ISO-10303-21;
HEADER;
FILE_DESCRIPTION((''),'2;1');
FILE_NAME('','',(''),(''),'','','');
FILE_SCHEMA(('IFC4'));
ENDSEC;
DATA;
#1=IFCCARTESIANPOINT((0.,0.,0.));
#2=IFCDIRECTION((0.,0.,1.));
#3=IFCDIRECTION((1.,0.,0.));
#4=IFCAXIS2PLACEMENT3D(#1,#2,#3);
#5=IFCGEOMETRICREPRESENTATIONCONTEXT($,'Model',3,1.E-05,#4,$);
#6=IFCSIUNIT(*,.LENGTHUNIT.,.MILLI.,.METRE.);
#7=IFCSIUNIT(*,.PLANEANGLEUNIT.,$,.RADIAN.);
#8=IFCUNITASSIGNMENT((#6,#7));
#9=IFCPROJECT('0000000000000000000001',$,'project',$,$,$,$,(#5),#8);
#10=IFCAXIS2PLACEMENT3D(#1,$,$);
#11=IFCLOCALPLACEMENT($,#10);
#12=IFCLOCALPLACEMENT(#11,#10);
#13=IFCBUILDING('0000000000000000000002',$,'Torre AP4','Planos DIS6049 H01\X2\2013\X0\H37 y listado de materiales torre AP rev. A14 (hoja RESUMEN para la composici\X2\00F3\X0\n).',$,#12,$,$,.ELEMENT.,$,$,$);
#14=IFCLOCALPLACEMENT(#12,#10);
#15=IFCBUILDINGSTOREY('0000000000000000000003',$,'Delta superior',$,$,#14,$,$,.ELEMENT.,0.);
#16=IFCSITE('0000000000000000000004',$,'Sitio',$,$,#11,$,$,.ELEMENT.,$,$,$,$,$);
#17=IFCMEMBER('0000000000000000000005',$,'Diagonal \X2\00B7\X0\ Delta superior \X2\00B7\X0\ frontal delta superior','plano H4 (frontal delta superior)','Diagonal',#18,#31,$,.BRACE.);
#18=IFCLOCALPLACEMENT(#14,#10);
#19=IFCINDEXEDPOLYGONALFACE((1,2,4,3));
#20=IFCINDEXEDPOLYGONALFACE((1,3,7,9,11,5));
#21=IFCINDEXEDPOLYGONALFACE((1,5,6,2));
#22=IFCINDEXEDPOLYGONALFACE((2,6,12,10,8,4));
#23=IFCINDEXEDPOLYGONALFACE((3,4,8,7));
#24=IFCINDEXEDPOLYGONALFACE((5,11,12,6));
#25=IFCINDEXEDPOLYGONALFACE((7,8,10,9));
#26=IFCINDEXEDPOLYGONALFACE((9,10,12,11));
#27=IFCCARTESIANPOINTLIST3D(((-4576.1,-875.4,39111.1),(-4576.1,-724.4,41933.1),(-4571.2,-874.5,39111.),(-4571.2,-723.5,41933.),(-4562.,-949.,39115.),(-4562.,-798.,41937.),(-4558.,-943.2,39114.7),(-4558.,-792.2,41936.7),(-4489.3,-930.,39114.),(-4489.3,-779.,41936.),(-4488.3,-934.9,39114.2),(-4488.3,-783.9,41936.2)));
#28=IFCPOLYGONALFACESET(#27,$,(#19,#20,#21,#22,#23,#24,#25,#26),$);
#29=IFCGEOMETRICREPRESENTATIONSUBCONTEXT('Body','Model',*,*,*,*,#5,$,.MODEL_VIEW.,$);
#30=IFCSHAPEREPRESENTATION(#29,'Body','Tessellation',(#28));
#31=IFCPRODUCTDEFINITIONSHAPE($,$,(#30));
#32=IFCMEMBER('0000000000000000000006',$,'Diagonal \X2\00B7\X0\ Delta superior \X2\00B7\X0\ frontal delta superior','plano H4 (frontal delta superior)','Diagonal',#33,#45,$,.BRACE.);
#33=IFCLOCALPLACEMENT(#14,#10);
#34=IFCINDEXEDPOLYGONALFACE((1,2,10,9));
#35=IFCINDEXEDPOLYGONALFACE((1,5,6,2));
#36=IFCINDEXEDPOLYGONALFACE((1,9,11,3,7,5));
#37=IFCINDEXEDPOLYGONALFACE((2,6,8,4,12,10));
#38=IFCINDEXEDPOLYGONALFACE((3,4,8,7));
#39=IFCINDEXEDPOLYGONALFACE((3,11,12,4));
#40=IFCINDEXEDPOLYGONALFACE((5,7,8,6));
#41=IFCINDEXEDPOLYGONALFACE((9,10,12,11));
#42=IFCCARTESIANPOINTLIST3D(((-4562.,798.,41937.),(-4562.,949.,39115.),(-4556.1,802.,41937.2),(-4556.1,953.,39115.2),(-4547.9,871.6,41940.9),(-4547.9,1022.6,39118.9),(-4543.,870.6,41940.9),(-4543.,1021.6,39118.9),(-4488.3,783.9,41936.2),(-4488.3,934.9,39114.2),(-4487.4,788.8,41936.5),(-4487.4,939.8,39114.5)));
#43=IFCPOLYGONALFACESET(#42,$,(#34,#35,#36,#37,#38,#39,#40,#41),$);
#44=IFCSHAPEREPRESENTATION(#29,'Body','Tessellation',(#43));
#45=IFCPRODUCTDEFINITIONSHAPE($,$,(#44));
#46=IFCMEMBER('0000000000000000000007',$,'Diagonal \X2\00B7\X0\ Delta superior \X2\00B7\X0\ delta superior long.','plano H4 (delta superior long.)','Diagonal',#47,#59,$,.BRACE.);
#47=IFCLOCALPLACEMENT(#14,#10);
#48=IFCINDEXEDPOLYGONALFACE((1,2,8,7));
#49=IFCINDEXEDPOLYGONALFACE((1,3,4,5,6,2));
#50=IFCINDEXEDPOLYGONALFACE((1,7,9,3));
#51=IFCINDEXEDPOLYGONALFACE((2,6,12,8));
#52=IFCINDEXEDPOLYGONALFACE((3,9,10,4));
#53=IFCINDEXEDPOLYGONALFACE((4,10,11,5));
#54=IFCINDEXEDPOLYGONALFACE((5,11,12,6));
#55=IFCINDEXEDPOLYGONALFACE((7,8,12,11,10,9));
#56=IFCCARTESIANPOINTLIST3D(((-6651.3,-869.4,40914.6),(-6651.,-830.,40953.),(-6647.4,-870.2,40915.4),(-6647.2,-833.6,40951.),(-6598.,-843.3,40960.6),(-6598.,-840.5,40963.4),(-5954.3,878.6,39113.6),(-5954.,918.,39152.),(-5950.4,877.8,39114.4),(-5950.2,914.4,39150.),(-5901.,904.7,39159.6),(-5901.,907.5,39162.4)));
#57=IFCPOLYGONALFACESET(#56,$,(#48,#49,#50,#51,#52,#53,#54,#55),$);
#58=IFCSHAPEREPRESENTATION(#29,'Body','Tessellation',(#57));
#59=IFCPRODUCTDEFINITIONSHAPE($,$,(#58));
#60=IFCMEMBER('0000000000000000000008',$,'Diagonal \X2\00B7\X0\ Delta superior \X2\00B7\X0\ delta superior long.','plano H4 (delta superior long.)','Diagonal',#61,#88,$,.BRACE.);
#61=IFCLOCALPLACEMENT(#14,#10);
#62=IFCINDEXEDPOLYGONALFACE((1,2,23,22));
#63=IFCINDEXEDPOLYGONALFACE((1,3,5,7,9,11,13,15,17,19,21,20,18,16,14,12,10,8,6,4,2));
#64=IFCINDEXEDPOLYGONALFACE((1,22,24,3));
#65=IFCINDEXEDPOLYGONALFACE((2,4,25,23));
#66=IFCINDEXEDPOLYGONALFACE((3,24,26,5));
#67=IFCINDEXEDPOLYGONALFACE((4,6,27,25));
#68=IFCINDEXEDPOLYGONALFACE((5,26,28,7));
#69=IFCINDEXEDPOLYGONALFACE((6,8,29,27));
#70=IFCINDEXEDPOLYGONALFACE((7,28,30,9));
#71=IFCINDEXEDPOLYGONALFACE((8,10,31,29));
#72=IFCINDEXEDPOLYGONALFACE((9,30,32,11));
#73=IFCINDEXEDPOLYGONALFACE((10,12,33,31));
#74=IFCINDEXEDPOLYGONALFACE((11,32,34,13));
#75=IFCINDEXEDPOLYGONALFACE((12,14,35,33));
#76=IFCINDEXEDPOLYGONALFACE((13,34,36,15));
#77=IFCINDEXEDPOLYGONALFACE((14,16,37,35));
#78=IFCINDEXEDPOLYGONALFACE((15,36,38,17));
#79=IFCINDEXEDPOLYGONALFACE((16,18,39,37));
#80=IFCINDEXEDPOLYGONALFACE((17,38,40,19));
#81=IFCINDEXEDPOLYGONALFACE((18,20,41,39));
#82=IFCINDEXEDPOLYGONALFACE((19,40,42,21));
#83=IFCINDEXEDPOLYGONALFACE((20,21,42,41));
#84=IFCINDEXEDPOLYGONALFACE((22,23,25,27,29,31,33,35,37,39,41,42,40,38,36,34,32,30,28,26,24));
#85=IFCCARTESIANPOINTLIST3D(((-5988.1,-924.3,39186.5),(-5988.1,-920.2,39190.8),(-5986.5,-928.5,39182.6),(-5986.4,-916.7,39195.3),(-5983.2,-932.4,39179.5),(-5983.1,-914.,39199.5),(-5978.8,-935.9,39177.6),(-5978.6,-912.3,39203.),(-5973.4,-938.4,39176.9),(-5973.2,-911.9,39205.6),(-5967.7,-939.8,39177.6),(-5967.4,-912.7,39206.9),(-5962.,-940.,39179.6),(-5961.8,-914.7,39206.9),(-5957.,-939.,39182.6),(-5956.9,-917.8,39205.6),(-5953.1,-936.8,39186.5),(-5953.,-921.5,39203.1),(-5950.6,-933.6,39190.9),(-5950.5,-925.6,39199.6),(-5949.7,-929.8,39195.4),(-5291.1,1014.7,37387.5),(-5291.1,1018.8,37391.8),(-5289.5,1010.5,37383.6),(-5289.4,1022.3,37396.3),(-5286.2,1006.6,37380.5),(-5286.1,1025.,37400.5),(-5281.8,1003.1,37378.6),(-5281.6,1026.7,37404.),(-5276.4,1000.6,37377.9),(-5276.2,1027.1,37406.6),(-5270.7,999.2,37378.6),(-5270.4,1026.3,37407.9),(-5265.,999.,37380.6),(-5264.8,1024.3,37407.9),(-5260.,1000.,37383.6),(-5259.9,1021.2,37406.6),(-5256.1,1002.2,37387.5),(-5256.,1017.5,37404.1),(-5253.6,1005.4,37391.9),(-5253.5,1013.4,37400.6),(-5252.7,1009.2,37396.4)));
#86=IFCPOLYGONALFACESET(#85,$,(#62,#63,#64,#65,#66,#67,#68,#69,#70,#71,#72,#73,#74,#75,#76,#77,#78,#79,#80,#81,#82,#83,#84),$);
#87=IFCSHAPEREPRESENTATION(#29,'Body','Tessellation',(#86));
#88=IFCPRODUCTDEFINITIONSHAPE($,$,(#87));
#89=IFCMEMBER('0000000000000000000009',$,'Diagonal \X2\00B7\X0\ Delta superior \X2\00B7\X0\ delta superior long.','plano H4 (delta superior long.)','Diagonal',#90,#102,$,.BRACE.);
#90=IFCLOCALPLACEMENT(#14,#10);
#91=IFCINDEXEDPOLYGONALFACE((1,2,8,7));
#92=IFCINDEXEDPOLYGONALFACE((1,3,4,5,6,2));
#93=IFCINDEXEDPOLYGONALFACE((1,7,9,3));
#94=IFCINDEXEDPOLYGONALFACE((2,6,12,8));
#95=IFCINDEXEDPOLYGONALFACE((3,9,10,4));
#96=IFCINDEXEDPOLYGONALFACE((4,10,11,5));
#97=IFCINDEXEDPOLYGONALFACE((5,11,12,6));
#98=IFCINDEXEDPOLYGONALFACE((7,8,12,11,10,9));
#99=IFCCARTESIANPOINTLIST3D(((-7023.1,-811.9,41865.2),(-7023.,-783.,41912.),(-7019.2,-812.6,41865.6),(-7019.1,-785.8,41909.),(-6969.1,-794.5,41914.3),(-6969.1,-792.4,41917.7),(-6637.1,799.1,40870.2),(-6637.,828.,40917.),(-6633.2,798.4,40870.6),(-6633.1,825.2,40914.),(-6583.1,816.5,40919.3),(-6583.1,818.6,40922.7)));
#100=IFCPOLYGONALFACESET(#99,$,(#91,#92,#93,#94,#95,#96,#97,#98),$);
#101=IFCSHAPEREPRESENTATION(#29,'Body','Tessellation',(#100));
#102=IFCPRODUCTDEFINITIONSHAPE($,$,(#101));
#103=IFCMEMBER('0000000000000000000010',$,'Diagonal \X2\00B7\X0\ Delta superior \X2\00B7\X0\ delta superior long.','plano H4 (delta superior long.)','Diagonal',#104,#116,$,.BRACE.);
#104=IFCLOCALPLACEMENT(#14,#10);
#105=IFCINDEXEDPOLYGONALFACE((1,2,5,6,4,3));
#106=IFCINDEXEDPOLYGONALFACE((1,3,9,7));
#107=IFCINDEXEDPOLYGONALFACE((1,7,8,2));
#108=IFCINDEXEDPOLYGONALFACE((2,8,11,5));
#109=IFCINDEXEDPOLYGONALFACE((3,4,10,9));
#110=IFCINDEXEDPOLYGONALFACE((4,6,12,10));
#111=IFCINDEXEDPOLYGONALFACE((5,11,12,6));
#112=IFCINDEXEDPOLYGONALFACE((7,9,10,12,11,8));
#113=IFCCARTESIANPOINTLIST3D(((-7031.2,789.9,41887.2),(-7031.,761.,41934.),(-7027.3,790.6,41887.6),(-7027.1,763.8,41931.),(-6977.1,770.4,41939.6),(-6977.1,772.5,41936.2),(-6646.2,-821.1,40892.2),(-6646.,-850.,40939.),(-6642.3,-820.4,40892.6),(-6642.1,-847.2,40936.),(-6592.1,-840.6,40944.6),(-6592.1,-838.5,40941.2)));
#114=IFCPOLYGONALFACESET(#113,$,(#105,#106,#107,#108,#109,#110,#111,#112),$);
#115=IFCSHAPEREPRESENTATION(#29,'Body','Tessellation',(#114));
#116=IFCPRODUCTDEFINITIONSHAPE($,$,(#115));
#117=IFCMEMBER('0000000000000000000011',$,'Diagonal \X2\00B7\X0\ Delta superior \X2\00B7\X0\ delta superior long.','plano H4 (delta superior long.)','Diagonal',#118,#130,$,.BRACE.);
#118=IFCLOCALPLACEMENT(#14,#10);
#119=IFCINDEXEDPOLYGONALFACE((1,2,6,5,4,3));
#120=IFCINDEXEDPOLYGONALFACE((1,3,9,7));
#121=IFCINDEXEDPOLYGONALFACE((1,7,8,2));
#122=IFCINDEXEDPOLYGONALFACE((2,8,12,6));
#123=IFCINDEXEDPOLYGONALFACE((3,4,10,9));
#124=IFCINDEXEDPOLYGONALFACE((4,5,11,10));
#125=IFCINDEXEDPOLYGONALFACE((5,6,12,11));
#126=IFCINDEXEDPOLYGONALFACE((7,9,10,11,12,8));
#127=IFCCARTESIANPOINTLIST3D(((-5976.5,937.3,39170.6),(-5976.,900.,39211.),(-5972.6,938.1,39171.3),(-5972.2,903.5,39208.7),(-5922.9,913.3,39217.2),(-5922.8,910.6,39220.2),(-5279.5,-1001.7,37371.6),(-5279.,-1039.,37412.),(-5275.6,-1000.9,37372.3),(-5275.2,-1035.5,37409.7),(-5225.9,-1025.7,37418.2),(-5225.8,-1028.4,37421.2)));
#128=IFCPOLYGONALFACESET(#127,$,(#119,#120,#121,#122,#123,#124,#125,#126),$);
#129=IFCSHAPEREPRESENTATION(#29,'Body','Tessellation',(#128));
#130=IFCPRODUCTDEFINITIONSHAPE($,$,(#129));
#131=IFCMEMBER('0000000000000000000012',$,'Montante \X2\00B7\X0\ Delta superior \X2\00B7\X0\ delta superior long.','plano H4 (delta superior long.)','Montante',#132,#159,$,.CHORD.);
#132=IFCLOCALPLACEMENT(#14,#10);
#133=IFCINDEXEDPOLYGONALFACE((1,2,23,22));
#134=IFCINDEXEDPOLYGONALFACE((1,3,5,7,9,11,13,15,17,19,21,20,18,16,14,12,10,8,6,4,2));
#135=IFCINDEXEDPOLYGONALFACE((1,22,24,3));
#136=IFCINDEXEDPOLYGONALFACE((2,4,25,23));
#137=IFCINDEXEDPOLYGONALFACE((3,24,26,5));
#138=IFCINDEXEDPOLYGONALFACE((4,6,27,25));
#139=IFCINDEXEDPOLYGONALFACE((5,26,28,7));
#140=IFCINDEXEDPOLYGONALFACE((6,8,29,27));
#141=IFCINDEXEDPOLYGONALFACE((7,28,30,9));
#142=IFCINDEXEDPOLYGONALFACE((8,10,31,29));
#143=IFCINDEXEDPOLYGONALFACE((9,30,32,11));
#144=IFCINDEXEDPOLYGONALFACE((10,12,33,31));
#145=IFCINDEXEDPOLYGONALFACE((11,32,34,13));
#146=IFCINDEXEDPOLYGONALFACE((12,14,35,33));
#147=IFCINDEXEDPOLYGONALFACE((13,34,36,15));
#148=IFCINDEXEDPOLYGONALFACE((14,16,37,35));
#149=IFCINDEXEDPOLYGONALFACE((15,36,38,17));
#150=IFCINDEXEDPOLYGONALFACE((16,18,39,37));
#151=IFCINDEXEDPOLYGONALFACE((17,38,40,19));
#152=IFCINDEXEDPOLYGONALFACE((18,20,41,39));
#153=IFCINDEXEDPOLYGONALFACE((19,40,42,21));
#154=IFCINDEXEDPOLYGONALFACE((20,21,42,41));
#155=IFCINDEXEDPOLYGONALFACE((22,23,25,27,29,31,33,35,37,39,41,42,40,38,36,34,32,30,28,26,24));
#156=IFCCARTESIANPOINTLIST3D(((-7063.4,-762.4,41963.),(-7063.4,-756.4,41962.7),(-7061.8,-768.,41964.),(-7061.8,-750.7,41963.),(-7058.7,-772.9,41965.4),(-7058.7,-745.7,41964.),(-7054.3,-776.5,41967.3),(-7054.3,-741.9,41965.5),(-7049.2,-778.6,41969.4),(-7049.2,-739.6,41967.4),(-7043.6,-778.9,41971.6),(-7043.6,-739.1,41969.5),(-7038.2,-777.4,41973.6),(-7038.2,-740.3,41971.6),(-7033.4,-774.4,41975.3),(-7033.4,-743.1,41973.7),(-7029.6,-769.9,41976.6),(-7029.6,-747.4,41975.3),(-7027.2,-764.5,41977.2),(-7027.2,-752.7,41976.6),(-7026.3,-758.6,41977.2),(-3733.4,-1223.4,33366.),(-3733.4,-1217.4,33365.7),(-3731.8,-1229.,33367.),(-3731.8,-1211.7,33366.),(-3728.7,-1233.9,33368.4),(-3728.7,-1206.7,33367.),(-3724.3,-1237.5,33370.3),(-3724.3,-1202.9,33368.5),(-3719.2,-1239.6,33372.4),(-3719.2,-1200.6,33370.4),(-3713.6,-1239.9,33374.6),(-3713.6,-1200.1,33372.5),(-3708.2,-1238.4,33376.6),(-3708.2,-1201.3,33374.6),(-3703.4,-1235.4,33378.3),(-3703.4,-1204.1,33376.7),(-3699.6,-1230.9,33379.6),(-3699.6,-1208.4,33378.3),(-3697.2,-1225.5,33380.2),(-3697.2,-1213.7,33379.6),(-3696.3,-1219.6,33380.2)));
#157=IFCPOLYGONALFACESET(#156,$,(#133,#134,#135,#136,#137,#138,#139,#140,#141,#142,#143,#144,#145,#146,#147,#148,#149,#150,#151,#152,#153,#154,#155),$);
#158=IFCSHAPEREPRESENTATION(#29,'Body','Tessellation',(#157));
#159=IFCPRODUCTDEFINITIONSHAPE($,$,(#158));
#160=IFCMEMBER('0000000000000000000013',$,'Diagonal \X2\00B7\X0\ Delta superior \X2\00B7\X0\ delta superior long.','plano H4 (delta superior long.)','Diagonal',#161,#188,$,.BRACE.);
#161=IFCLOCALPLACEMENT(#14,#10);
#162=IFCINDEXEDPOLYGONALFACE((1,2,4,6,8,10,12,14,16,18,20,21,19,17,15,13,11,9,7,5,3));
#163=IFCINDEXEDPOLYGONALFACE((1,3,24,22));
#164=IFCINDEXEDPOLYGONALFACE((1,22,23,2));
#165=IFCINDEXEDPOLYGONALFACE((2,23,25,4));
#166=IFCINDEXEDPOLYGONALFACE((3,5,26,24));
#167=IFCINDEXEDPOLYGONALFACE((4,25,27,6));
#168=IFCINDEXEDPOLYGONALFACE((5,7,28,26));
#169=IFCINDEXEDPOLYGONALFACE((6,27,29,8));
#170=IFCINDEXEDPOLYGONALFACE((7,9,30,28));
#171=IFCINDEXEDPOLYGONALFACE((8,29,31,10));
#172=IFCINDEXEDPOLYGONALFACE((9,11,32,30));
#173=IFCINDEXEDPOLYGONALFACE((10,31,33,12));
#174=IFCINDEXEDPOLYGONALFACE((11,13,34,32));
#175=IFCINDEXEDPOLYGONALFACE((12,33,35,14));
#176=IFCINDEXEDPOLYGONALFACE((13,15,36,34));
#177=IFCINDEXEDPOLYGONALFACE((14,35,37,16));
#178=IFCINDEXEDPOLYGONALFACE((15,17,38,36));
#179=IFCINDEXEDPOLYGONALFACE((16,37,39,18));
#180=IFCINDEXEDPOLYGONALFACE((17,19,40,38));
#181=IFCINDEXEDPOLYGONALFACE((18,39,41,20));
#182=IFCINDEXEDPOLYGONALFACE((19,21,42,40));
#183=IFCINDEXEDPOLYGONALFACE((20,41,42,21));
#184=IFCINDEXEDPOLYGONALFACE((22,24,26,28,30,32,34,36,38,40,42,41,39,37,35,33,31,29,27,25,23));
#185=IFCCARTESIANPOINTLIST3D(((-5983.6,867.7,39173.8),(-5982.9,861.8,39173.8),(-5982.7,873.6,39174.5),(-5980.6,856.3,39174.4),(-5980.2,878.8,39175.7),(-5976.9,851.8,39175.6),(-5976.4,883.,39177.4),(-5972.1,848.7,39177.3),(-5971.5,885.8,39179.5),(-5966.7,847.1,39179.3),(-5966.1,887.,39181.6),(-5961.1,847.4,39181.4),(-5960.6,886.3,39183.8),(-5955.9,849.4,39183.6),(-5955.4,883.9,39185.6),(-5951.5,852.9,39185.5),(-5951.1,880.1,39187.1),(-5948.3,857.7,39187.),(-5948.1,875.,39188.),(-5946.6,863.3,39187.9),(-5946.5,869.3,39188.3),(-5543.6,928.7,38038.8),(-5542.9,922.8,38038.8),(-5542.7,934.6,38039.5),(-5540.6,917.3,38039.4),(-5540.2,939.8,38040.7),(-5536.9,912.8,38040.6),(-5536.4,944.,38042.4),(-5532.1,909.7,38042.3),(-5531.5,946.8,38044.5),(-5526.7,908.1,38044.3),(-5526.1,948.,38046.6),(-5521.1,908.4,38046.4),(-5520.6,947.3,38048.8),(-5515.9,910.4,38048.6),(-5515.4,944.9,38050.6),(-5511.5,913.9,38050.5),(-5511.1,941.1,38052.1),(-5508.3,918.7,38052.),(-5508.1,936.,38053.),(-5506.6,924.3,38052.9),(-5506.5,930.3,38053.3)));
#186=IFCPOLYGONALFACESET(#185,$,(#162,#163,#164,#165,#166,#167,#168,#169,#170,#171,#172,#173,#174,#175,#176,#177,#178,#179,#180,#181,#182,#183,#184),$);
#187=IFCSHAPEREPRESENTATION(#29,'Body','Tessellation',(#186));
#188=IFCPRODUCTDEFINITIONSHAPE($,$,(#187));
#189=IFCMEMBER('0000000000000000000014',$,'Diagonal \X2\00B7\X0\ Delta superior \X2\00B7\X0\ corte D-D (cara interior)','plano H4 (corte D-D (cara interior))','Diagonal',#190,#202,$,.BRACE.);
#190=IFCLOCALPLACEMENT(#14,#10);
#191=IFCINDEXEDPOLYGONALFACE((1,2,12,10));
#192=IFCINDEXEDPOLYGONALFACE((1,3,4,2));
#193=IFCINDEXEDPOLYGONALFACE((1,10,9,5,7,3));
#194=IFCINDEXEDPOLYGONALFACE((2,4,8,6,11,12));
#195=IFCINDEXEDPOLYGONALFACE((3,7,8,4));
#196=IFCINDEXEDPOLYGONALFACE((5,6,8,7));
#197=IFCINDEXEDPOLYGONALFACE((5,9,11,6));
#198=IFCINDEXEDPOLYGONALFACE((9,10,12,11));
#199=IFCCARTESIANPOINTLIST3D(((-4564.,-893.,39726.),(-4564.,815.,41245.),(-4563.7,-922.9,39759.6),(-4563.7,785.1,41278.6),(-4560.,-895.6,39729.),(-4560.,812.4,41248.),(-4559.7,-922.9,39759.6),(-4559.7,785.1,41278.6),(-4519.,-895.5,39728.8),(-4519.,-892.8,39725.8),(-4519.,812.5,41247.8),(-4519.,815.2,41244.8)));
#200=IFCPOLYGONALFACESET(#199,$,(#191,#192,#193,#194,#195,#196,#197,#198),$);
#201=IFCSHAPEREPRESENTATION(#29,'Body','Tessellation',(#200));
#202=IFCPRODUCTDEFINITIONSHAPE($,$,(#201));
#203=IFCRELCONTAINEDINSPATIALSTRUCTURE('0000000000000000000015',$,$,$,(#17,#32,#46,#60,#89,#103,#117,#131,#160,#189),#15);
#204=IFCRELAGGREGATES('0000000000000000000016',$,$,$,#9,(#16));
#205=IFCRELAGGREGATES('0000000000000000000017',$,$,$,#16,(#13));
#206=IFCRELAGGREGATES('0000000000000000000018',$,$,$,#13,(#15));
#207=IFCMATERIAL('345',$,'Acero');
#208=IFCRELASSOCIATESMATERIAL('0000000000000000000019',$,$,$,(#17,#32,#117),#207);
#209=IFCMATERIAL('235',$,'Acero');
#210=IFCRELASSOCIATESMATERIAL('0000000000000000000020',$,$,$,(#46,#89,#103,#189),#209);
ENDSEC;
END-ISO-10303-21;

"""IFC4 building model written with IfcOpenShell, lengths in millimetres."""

from ifc_helpers import new_model, si_unit, frame, frame_2d, origin, origin_with_axes, place, context, subcontext, project, spatial, circle, l_section, extrude, material, element, save


model = new_model("IFC4")

# Units and contexts
model_context = context("Model", 3, precision=1e-05, world=origin_with_axes())
body_context = subcontext(model_context, "Body", "Model", "MODEL_VIEW")
ifc_project = project(units=[si_unit("LENGTHUNIT", "METRE", prefix="MILLI"), si_unit("PLANEANGLEUNIT", "RADIAN")], contexts=[model_context])

# Site, building, storey
site_placement = place(None, origin())
site = spatial("IfcSite", under=ifc_project, at=site_placement, Name="Sitio", CompositionType="ELEMENT")
building_placement = place(site_placement, origin())
building = spatial("IfcBuilding", under=site, at=building_placement, Name="Torre AP4", Description="Planos DIS6049 H01–H37 y listado de materiales torre AP rev. A14 (hoja RESUMEN para la composición).", CompositionType="ELEMENT")
storey_placement = place(building_placement, origin())
storey = spatial("IfcBuildingStorey", under=building, at=storey_placement, Name="Delta superior", CompositionType="ELEMENT", Elevation=0.0)

# Members
ifc_material_1 = material(Name="235", Category="Acero")
ifc_material_2 = material(Name="345", Category="Acero")
for number, where, z_axis, x_axis, name in (
    (1, (-4562.0, -949.0, 39115.0), (0.0, 0.053432, 0.998572), (0.982208, 0.187529, -0.010034), "Diagonal · Delta superior · frontal delta superior"),
    (2, (-4562.0, 949.0, 39115.0), (0.0, -0.053432, 0.998572), (0.982208, -0.187529, -0.010034), "Diagonal · Delta superior · frontal delta superior"),
):
    element("IfcMember", number, at=place(storey_placement, frame(where, z_axis=z_axis, x_axis=x_axis)), inside=storey, material=ifc_material_2, Name=name, Description="plano H4 (frontal delta superior)", ObjectType="Diagonal", PredefinedType="BRACE", context=body_context, shape_type="SweptSolid", body=[
        extrude(l_section(Depth=75.0, Width=75.0, Thickness=5.0, at=frame_2d((37.5, 37.5))), None, (0.0, 0.0, 1.0), 2826.0),
    ])
member_1_placement = place(storey_placement, frame((-6651.0, -830.0, 40953.0), z_axis=(0.267584, 0.671072, -0.691419), x_axis=(0.963521, -0.190088, 0.188396)))
element("IfcMember", 3, at=member_1_placement, inside=storey, material=ifc_material_1, Name="Diagonal · Delta superior · delta superior long.", Description="plano H4 (delta superior long.)", ObjectType="Diagonal", PredefinedType="BRACE", context=body_context, shape_type="SweptSolid", body=[
    extrude(l_section(Depth=55.0, Width=55.0, Thickness=4.0, at=frame_2d((27.5, 27.5))), None, (0.0, 0.0, 1.0), 2604.8),
])
member_2_placement = place(storey_placement, frame((-5969.0, -926.0, 39192.0), z_axis=(0.254816, 0.708877, -0.657695), x_axis=(0.966975, -0.190493, 0.169325)))
element("IfcMember", 4, at=member_2_placement, inside=storey, Name="Diagonal · Delta superior · delta superior long.", Description="plano H4 (delta superior long.)", ObjectType="Diagonal", PredefinedType="BRACE", context=body_context, shape_type="SweptSolid", body=[
    extrude(circle(Radius=20.0), None, (0.0, 0.0, 1.0), 2735.3),
])
member_3_placement = place(storey_placement, frame((-7023.0, -783.0, 41912.0), z_axis=(0.199747, 0.833659, -0.514892), x_axis=(0.979846, -0.170873, 0.103461)))
element("IfcMember", 5, at=member_3_placement, inside=storey, material=ifc_material_1, Name="Diagonal · Delta superior · delta superior long.", Description="plano H4 (delta superior long.)", ObjectType="Diagonal", PredefinedType="BRACE", context=body_context, shape_type="SweptSolid", body=[
    extrude(l_section(Depth=55.0, Width=55.0, Thickness=4.0, at=frame_2d((27.5, 27.5))), None, (0.0, 0.0, 1.0), 1932.4),
])
member_4_placement = place(storey_placement, frame((-6646.0, -850.0, 40939.0), z_axis=(-0.19925, 0.833745, 0.514945), x_axis=(0.979943, 0.171353, 0.101736)))
element("IfcMember", 6, at=member_4_placement, inside=storey, material=ifc_material_1, Name="Diagonal · Delta superior · delta superior long.", Description="plano H4 (delta superior long.)", ObjectType="Diagonal", PredefinedType="BRACE", context=body_context, shape_type="SweptSolid", body=[
    extrude(l_section(Depth=55.0, Width=55.0, Thickness=4.0, at=frame_2d((27.5, 27.5))), None, (0.0, 0.0, 1.0), 1932.2),
])
member_5_placement = place(storey_placement, frame((-5279.0, -1039.0, 37412.0), z_axis=(-0.254816, 0.708877, 0.657695), x_axis=(0.966953, 0.192686, 0.166953)))
element("IfcMember", 7, at=member_5_placement, inside=storey, material=ifc_material_2, Name="Diagonal · Delta superior · delta superior long.", Description="plano H4 (delta superior long.)", ObjectType="Diagonal", PredefinedType="BRACE", context=body_context, shape_type="SweptSolid", body=[
    extrude(l_section(Depth=55.0, Width=55.0, Thickness=4.0, at=frame_2d((27.5, 27.5))), None, (0.0, 0.0, 1.0), 2735.3),
])
for number, where, z_axis, x_axis, name in (
    (8, (-3715.0, -1220.0, 33373.0), (-0.360744, 0.049941, 0.931327), (0.932665, 0.019317, 0.360227), "Montante · Delta superior · delta superior long."),
):
    element("IfcMember", number, at=place(storey_placement, frame(where, z_axis=z_axis, x_axis=x_axis)), inside=storey, Name=name, Description="plano H4 (delta superior long.)", ObjectType="Montante", PredefinedType="CHORD", context=body_context, shape_type="SweptSolid", body=[
        extrude(circle(Radius=20.0), None, (0.0, 0.0, 1.0), 9230.9),
    ])
member_6_placement = place(storey_placement, frame((-5525.0, 928.0, 38046.0), z_axis=(-0.361002, -0.050048, 0.931221), x_axis=(0.919866, -0.183339, 0.346747)))
element("IfcMember", 9, at=member_6_placement, inside=storey, Name="Diagonal · Delta superior · delta superior long.", Description="plano H4 (delta superior long.)", ObjectType="Diagonal", PredefinedType="BRACE", context=body_context, shape_type="SweptSolid", body=[
    extrude(circle(Radius=20.0), None, (0.0, 0.0, 1.0), 1218.8),
])
member_7_placement = place(storey_placement, frame((-4564.0, 815.0, 41245.0), z_axis=(0.0, -0.74724, -0.664554), x_axis=(0.999984, 0.003774, -0.004243)))
element("IfcMember", 10, at=member_7_placement, inside=storey, material=ifc_material_1, Name="Diagonal · Delta superior · corte D-D (cara interior)", Description="plano H4 (corte D-D (cara interior))", ObjectType="Diagonal", PredefinedType="BRACE", context=body_context, shape_type="SweptSolid", body=[
    extrude(l_section(Depth=45.0, Width=45.0, Thickness=4.0, at=frame_2d((22.5, 22.5))), None, (0.0, 0.0, 1.0), 2285.7),
])

save(model, "model.ifc")
